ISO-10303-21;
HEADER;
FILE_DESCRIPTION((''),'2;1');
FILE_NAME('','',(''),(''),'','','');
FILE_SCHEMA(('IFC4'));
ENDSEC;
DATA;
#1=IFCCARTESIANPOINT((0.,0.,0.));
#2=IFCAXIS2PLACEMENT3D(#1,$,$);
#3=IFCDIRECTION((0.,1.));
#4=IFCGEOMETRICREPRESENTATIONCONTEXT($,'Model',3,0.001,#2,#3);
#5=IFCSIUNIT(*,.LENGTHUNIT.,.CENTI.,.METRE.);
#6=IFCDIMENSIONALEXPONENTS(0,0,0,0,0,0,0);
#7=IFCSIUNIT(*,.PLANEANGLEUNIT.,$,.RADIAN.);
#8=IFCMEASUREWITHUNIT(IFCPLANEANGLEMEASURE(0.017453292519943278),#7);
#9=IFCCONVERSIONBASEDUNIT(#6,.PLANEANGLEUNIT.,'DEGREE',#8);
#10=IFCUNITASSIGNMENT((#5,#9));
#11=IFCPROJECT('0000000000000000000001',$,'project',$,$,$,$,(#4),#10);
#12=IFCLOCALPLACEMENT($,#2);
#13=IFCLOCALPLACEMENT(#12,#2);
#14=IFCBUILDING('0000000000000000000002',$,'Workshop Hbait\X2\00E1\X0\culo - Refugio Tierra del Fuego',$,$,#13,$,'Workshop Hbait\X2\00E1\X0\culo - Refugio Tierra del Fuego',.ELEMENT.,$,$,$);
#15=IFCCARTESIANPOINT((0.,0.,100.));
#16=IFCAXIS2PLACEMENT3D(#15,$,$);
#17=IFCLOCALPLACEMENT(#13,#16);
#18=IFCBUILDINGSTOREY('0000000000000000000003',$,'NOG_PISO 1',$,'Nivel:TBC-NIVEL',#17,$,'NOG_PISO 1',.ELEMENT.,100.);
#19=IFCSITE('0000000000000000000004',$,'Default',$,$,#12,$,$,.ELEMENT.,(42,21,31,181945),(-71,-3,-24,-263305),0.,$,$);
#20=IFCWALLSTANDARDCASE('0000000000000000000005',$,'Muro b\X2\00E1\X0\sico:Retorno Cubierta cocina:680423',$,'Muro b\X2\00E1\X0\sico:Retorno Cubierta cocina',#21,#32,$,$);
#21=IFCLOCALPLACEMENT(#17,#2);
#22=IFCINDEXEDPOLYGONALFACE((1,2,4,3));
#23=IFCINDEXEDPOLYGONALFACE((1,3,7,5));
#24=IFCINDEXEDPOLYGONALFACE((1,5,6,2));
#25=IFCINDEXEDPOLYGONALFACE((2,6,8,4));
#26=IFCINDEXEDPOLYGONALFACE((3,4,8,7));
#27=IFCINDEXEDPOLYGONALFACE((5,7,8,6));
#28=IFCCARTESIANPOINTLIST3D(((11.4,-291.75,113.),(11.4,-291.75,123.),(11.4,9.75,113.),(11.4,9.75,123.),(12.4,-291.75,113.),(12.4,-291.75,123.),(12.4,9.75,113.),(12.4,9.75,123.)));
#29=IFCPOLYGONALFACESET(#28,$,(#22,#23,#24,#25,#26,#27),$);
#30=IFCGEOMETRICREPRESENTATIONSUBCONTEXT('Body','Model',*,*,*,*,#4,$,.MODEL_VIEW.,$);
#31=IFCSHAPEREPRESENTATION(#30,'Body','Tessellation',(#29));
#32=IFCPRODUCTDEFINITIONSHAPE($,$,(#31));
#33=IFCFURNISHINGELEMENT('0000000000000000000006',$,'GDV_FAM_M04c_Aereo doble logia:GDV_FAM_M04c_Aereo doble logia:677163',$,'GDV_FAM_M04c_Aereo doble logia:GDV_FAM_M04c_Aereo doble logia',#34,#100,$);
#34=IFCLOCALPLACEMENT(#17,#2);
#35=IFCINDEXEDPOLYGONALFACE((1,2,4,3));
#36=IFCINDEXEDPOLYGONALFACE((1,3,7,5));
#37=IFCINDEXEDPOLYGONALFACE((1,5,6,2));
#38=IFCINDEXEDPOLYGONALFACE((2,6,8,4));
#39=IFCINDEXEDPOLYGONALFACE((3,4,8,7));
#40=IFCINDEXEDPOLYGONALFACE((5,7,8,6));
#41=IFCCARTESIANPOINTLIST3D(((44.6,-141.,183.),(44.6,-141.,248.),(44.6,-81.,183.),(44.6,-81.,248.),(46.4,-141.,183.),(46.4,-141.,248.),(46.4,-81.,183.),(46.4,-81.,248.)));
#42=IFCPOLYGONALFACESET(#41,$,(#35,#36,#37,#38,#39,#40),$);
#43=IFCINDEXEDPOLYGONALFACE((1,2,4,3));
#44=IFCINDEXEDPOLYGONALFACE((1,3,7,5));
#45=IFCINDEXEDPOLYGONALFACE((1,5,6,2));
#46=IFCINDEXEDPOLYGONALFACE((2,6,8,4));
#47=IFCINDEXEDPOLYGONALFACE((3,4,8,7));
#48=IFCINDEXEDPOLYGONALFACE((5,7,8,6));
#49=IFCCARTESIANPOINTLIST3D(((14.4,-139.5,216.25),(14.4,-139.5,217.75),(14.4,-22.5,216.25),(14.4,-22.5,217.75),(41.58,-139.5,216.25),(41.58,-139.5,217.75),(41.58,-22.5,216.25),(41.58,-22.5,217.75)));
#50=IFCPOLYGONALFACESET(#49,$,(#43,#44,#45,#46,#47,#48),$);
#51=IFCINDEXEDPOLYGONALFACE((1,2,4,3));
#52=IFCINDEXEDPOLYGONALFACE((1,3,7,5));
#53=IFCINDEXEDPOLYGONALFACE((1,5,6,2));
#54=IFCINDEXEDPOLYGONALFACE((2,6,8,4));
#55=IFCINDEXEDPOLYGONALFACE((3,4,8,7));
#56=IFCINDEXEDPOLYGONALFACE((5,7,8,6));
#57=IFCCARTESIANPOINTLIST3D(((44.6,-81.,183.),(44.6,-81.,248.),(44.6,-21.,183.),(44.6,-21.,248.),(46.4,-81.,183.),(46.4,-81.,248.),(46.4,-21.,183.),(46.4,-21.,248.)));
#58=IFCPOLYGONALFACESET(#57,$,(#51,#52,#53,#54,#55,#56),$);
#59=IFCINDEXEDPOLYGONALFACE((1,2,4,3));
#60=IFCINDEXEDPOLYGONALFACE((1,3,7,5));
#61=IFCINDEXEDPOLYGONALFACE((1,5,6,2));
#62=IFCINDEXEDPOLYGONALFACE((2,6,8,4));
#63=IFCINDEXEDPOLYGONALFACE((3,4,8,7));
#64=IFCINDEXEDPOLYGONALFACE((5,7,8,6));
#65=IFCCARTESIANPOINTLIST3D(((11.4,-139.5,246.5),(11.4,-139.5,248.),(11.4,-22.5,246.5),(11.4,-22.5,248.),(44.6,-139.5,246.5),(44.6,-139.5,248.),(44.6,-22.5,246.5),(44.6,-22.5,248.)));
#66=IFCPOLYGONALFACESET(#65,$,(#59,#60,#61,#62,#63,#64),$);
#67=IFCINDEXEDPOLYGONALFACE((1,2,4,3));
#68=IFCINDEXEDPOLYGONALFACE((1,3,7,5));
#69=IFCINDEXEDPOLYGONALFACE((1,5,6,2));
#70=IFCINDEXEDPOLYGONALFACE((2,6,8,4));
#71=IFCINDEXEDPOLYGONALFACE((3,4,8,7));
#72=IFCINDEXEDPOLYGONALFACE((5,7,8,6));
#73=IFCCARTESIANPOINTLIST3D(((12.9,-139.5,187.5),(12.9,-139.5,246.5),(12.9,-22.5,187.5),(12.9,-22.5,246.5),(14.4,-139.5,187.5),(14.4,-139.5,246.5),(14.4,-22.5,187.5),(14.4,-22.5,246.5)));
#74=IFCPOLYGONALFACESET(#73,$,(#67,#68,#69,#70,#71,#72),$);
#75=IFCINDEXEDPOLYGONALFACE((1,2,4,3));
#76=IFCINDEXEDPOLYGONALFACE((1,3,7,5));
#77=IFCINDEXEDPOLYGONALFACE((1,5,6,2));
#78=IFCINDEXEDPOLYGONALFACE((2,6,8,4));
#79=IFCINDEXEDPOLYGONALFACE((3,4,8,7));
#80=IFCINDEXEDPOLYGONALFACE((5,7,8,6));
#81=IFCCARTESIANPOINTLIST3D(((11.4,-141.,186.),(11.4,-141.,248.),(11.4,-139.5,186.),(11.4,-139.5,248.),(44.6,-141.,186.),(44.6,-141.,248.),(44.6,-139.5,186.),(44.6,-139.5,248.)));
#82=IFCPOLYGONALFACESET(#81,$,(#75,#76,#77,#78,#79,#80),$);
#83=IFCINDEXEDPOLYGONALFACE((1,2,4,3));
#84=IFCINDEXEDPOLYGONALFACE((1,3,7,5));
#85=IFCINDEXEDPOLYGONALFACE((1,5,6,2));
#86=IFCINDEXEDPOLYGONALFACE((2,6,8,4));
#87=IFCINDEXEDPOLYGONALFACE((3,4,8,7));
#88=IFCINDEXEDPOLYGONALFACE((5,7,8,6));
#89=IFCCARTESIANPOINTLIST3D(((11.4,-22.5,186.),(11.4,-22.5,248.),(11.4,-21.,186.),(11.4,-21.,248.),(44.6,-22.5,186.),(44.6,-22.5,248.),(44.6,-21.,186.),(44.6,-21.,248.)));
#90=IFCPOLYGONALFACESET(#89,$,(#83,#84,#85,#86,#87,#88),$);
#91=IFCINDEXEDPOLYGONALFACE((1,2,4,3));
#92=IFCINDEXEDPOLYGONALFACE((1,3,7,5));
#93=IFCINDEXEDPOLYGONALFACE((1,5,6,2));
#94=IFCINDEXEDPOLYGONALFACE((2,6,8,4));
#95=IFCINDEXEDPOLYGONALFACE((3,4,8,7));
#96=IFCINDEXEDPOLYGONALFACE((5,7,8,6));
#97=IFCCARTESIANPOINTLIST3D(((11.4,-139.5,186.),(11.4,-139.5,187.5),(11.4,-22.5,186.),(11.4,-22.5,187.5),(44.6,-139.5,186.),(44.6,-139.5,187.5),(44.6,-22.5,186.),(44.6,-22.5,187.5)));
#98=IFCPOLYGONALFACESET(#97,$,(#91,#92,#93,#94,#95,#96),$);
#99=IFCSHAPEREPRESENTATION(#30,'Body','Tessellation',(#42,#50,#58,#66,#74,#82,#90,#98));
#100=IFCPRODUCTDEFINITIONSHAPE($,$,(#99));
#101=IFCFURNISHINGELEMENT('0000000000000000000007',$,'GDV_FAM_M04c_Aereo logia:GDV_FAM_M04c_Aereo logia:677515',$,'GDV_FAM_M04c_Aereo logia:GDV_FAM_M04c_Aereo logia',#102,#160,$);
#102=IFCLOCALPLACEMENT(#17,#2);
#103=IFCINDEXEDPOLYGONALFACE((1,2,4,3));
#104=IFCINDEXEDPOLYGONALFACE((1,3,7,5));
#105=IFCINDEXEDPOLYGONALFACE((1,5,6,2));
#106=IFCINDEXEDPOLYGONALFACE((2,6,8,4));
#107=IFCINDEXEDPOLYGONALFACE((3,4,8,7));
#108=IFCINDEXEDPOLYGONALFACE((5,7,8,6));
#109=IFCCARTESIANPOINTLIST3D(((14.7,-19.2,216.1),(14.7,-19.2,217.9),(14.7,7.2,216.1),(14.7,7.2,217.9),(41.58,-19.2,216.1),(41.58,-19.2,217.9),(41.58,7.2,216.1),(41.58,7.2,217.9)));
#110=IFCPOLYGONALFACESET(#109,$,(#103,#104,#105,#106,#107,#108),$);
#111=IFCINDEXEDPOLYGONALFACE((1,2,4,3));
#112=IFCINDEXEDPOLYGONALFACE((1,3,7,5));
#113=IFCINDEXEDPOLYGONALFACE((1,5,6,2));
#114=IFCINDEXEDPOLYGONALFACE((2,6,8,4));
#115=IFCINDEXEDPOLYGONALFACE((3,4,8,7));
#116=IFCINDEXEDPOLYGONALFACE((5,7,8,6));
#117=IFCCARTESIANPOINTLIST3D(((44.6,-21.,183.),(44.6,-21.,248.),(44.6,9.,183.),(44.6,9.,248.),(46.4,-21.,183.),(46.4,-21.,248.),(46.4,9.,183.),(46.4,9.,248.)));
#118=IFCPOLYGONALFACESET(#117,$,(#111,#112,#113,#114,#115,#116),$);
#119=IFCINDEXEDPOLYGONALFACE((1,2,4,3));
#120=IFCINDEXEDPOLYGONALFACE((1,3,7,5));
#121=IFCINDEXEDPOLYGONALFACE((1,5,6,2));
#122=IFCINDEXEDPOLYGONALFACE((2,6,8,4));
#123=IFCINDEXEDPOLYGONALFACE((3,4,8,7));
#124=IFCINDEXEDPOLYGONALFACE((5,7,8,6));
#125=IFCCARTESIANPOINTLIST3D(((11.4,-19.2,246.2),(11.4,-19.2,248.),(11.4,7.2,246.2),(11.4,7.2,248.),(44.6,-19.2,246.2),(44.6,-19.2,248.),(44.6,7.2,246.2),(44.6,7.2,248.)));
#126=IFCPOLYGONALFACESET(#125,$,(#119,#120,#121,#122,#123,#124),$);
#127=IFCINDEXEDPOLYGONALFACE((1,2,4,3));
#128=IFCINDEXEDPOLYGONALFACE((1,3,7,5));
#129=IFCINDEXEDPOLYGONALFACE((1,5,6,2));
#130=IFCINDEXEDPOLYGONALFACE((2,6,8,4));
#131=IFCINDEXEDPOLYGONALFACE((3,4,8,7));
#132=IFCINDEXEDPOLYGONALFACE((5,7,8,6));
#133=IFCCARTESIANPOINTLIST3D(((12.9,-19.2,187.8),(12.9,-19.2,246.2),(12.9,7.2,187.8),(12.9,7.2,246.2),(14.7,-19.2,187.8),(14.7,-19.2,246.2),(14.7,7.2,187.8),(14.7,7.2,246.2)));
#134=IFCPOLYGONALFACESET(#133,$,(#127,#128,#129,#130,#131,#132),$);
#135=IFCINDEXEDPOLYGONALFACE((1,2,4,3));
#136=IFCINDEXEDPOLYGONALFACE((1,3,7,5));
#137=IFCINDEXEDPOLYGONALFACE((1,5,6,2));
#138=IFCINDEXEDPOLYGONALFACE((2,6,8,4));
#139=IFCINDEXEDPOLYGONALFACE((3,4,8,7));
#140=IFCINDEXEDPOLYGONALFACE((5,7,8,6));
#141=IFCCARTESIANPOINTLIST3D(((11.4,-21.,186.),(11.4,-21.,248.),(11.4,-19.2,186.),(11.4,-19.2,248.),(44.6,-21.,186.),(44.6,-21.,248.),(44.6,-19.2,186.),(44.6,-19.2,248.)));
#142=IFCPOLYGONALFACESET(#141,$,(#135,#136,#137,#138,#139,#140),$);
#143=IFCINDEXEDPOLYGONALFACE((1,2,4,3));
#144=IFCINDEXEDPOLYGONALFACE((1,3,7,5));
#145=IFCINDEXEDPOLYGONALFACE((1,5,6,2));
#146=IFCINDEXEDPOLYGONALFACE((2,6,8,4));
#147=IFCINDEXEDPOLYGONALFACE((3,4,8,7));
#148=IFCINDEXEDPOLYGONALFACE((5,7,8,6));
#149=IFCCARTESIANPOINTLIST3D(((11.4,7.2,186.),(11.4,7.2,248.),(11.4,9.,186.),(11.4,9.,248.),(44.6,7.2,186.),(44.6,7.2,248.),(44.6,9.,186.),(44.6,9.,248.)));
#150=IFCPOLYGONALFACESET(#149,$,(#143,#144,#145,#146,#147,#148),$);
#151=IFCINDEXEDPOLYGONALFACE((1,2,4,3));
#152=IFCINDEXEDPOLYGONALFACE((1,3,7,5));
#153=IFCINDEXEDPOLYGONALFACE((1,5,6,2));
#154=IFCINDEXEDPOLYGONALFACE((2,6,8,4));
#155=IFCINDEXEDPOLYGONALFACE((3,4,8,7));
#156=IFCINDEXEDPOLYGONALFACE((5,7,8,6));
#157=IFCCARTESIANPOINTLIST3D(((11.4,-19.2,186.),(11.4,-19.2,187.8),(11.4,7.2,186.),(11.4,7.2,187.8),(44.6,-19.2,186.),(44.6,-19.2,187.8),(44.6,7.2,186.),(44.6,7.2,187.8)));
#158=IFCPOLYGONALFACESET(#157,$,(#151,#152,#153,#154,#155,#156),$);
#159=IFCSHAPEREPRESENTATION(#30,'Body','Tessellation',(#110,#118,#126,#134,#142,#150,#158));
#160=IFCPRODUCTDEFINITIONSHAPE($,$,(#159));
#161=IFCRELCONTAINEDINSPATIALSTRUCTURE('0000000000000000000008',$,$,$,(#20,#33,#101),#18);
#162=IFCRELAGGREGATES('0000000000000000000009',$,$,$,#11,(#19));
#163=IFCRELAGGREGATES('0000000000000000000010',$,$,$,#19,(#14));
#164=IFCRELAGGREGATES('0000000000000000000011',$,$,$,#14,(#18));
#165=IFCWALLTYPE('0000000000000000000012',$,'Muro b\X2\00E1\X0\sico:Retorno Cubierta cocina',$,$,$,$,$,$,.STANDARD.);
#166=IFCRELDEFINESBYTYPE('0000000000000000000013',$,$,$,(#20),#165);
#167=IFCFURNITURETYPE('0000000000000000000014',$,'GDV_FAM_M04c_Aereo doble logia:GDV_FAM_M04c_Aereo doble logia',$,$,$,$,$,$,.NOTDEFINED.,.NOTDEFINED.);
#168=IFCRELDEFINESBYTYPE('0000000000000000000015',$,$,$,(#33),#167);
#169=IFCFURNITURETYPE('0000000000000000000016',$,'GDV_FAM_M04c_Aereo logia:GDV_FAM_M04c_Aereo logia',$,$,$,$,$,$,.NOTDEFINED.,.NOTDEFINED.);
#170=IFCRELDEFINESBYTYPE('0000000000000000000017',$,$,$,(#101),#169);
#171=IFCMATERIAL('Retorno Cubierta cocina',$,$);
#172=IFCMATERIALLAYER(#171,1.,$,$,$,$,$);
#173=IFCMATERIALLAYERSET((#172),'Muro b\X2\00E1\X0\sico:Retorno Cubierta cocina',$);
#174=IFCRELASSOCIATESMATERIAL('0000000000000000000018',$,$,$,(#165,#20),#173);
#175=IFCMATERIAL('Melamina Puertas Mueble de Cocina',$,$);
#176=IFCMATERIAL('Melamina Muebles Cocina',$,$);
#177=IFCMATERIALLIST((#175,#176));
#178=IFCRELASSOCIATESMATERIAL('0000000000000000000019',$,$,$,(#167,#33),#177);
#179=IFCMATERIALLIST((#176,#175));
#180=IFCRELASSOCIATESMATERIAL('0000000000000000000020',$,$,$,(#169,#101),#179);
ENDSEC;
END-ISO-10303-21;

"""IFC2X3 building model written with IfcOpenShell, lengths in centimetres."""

from ifc_helpers import new_model, entity, si_unit, converted_unit, direction, frame, frame_2d, origin, origin_2d_with_axis, place, context, subcontext, project, spatial, rectangle, extrude, source, transform, mapped, material, material_list, layer, layer_set, layer_usage, type_object, type_shapes, element, save


model = new_model("IFC2X3")

# Units and contexts
model_context = context("Model", 3, precision=0.001, world=origin(), true_north=direction((0.0, 1.0)))
body_context = subcontext(model_context, "Body", "Model", "MODEL_VIEW")
ifc_project = project(units=[si_unit("LENGTHUNIT", "METRE", prefix="CENTI"), converted_unit("PLANEANGLEUNIT", "DEGREE", entity("IfcPlaneAngleMeasure", 0.017453292519943278), si_unit("PLANEANGLEUNIT", "RADIAN"), dimensions=[0, 0, 0, 0, 0, 0, 0])], contexts=[model_context])

# Site, building, storey
site_placement = place(None, origin())
site = spatial("IfcSite", under=ifc_project, at=site_placement, Name="Default", CompositionType="ELEMENT", RefLatitude=(42, 21, 31, 181945), RefLongitude=(-71, -3, -24, -263305), RefElevation=0.0)
building_placement = place(site_placement, origin())
building = spatial("IfcBuilding", under=site, at=building_placement, Name="Workshop Hbaitáculo - Refugio Tierra del Fuego", LongName="Workshop Hbaitáculo - Refugio Tierra del Fuego", CompositionType="ELEMENT")
storey_placement = place(building_placement, frame((0.0, 0.0, 100.0)))
storey = spatial("IfcBuildingStorey", under=building, at=storey_placement, Name="NOG_PISO 1", ObjectType="Nivel:TBC-NIVEL", LongName="NOG_PISO 1", CompositionType="ELEMENT", Elevation=100.0)

# Wall
ifc_material_1 = material(Name="Retorno Cubierta cocina")
ifc_layer_1 = layer(ifc_material_1, 1.0)
ifc_layer_set_1 = layer_set([ifc_layer_1], Name="Muro básico:Retorno Cubierta cocina")
ifc_layer_usage_1 = layer_usage(ifc_layer_set_1, "AXIS2", "NEGATIVE", 0.5)
wall_type_1 = type_object("IfcWallType", Name="Muro básico:Retorno Cubierta cocina", PredefinedType="STANDARD", material=ifc_layer_set_1)
wall_1_placement = place(storey_placement, frame((11.9, 9.75, 113.0), z_axis=(0.0, 0.0, 1.0), x_axis=(0.0, -1.0, 0.0)))
element("IfcWallStandardCase", 1, at=wall_1_placement, inside=storey, type_object=wall_type_1, material=ifc_layer_usage_1, Name="Muro básico:Retorno Cubierta cocina:680423", ObjectType="Muro básico:Retorno Cubierta cocina", context=body_context, shape_type="SweptSolid", body=[
    extrude(rectangle(XDim=301.5, YDim=1.0, at=frame_2d((150.75, 0.0), x_axis=(-1.0, 0.0))), origin(), (0.0, 0.0, 1.0), 10.0),
])

# Furnishing elements
ifc_material_2 = material(Name="Melamina Puertas Mueble de Cocina")
ifc_material_3 = material(Name="Melamina Muebles Cocina")
ifc_material_list_1 = material_list([ifc_material_2, ifc_material_3])
furniture_type_1 = type_object("IfcFurnitureType", Name="GDV_FAM_M04c_Aereo doble logia:GDV_FAM_M04c_Aereo doble logia", AssemblyPlace="NOTDEFINED", material=ifc_material_list_1)
shared_shape_1 = source(origin(), body_context, "Body", "SweptSolid", [
    extrude(rectangle(XDim=1.8, YDim=60.0, at=frame_2d((0.0, 0.0), x_axis=(1.0, 0.0))), frame((90.0, 34.1, 0.0), z_axis=(0.0, 0.0, 1.0), x_axis=(0.0, 1.0, 0.0)), (0.0, 0.0, 1.0), 65.0),
    extrude(rectangle(XDim=27.18, YDim=117.0, at=frame_2d((0.0, 0.0), x_axis=(1.0, 0.0))), frame((60.0, 16.59, 33.25), z_axis=(0.0, 0.0, 1.0), x_axis=(0.0, 1.0, 0.0)), (0.0, 0.0, 1.0), 1.5),
    extrude(rectangle(XDim=1.8, YDim=60.0, at=frame_2d((0.0, 0.0), x_axis=(1.0, 0.0))), frame((30.0, 34.1, 0.0), z_axis=(0.0, 0.0, 1.0), x_axis=(0.0, 1.0, 0.0)), (0.0, 0.0, 1.0), 65.0),
    extrude(rectangle(XDim=33.2, YDim=117.0, at=frame_2d((0.0, 0.0), x_axis=(1.0, 0.0))), frame((60.0, 16.6, 63.5), z_axis=(0.0, 0.0, 1.0), x_axis=(0.0, 1.0, 0.0)), (0.0, 0.0, 1.0), 1.5),
    extrude(rectangle(XDim=1.5, YDim=117.0, at=frame_2d((0.0, 0.0), x_axis=(1.0, 0.0))), frame((60.0, 2.25, 4.5), z_axis=(0.0, 0.0, 1.0), x_axis=(0.0, 1.0, 0.0)), (0.0, 0.0, 1.0), 59.0),
    extrude(rectangle(XDim=1.5, YDim=33.2, at=frame_2d((0.0, 0.0), x_axis=(1.0, 0.0))), frame((119.25, 16.6, 3.0), z_axis=(0.0, 0.0, 1.0), x_axis=(-1.0, 0.0, 0.0)), (0.0, 0.0, 1.0), 62.0),
    extrude(rectangle(XDim=1.5, YDim=33.2, at=origin_2d_with_axis()), frame((0.75, 16.6, 3.0), z_axis=(0.0, 0.0, 1.0), x_axis=(-1.0, 0.0, 0.0)), (0.0, 0.0, 1.0), 62.0),
    extrude(rectangle(XDim=33.2, YDim=117.0, at=frame_2d((0.0, 0.0), x_axis=(1.0, 0.0))), frame((60.0, 16.6, 3.0), z_axis=(0.0, 0.0, 1.0), x_axis=(0.0, 1.0, 0.0)), (0.0, 0.0, 1.0), 1.5),
])
type_shapes(furniture_type_1, [shared_shape_1])
furnishing_1_placement = place(storey_placement, frame((11.4, -21.0, 183.0), z_axis=(0.0, 0.0, 1.0), x_axis=(0.0, -1.0, 0.0)))
element("IfcFurnishingElement", 2, at=furnishing_1_placement, inside=storey, type_object=furniture_type_1, material=ifc_material_list_1, Name="GDV_FAM_M04c_Aereo doble logia:GDV_FAM_M04c_Aereo doble logia:677163", ObjectType="GDV_FAM_M04c_Aereo doble logia:GDV_FAM_M04c_Aereo doble logia", context=body_context, shape_type="MappedRepresentation", body=[
    mapped(shared_shape_1, transform((0.0, 0.0, 0.0), scale=1.0)),
])
ifc_material_list_2 = material_list([ifc_material_3, ifc_material_2])
furniture_type_2 = type_object("IfcFurnitureType", Name="GDV_FAM_M04c_Aereo logia:GDV_FAM_M04c_Aereo logia", AssemblyPlace="NOTDEFINED", material=ifc_material_list_2)
shared_shape_2 = source(origin(), body_context, "Body", "SweptSolid", [
    extrude(rectangle(XDim=26.88, YDim=26.4, at=frame_2d((0.0, 0.0), x_axis=(1.0, 0.0))), frame((15.0, 16.74, 33.1), z_axis=(0.0, 0.0, 1.0), x_axis=(0.0, 1.0, 0.0)), (0.0, 0.0, 1.0), 1.8),
    extrude(rectangle(XDim=1.8, YDim=30.0, at=frame_2d((0.0, 0.0), x_axis=(1.0, 0.0))), frame((15.0, 34.1, 0.0), z_axis=(0.0, 0.0, 1.0), x_axis=(0.0, 1.0, 0.0)), (0.0, 0.0, 1.0), 65.0),
    extrude(rectangle(XDim=33.2, YDim=26.4, at=frame_2d((0.0, 0.0), x_axis=(1.0, 0.0))), frame((15.0, 16.6, 63.2), z_axis=(0.0, 0.0, 1.0), x_axis=(0.0, 1.0, 0.0)), (0.0, 0.0, 1.0), 1.8),
    extrude(rectangle(XDim=1.8, YDim=26.4, at=origin_2d_with_axis()), frame((15.0, 2.4, 4.8), z_axis=(0.0, 0.0, 1.0), x_axis=(0.0, 1.0, 0.0)), (0.0, 0.0, 1.0), 58.4),
    extrude(rectangle(XDim=1.8, YDim=33.2, at=origin_2d_with_axis()), frame((29.1, 16.6, 3.0), z_axis=(0.0, 0.0, 1.0), x_axis=(-1.0, 0.0, 0.0)), (0.0, 0.0, 1.0), 62.0),
    extrude(rectangle(XDim=1.8, YDim=33.2, at=origin_2d_with_axis()), frame((0.9, 16.6, 3.0), z_axis=(0.0, 0.0, 1.0), x_axis=(-1.0, 0.0, 0.0)), (0.0, 0.0, 1.0), 62.0),
    extrude(rectangle(XDim=33.2, YDim=26.4, at=origin_2d_with_axis()), frame((15.0, 16.6, 3.0), z_axis=(0.0, 0.0, 1.0), x_axis=(0.0, 1.0, 0.0)), (0.0, 0.0, 1.0), 1.8),
])
type_shapes(furniture_type_2, [shared_shape_2])
furnishing_2_placement = place(storey_placement, frame((11.4, 9.0, 183.0), z_axis=(0.0, 0.0, 1.0), x_axis=(0.0, -1.0, 0.0)))
element("IfcFurnishingElement", 3, at=furnishing_2_placement, inside=storey, type_object=furniture_type_2, material=ifc_material_list_2, Name="GDV_FAM_M04c_Aereo logia:GDV_FAM_M04c_Aereo logia:677515", ObjectType="GDV_FAM_M04c_Aereo logia:GDV_FAM_M04c_Aereo logia", context=body_context, shape_type="MappedRepresentation", body=[
    mapped(shared_shape_2, transform((0.0, 0.0, 0.0), scale=1.0)),
])

save(model, "model.ifc")
